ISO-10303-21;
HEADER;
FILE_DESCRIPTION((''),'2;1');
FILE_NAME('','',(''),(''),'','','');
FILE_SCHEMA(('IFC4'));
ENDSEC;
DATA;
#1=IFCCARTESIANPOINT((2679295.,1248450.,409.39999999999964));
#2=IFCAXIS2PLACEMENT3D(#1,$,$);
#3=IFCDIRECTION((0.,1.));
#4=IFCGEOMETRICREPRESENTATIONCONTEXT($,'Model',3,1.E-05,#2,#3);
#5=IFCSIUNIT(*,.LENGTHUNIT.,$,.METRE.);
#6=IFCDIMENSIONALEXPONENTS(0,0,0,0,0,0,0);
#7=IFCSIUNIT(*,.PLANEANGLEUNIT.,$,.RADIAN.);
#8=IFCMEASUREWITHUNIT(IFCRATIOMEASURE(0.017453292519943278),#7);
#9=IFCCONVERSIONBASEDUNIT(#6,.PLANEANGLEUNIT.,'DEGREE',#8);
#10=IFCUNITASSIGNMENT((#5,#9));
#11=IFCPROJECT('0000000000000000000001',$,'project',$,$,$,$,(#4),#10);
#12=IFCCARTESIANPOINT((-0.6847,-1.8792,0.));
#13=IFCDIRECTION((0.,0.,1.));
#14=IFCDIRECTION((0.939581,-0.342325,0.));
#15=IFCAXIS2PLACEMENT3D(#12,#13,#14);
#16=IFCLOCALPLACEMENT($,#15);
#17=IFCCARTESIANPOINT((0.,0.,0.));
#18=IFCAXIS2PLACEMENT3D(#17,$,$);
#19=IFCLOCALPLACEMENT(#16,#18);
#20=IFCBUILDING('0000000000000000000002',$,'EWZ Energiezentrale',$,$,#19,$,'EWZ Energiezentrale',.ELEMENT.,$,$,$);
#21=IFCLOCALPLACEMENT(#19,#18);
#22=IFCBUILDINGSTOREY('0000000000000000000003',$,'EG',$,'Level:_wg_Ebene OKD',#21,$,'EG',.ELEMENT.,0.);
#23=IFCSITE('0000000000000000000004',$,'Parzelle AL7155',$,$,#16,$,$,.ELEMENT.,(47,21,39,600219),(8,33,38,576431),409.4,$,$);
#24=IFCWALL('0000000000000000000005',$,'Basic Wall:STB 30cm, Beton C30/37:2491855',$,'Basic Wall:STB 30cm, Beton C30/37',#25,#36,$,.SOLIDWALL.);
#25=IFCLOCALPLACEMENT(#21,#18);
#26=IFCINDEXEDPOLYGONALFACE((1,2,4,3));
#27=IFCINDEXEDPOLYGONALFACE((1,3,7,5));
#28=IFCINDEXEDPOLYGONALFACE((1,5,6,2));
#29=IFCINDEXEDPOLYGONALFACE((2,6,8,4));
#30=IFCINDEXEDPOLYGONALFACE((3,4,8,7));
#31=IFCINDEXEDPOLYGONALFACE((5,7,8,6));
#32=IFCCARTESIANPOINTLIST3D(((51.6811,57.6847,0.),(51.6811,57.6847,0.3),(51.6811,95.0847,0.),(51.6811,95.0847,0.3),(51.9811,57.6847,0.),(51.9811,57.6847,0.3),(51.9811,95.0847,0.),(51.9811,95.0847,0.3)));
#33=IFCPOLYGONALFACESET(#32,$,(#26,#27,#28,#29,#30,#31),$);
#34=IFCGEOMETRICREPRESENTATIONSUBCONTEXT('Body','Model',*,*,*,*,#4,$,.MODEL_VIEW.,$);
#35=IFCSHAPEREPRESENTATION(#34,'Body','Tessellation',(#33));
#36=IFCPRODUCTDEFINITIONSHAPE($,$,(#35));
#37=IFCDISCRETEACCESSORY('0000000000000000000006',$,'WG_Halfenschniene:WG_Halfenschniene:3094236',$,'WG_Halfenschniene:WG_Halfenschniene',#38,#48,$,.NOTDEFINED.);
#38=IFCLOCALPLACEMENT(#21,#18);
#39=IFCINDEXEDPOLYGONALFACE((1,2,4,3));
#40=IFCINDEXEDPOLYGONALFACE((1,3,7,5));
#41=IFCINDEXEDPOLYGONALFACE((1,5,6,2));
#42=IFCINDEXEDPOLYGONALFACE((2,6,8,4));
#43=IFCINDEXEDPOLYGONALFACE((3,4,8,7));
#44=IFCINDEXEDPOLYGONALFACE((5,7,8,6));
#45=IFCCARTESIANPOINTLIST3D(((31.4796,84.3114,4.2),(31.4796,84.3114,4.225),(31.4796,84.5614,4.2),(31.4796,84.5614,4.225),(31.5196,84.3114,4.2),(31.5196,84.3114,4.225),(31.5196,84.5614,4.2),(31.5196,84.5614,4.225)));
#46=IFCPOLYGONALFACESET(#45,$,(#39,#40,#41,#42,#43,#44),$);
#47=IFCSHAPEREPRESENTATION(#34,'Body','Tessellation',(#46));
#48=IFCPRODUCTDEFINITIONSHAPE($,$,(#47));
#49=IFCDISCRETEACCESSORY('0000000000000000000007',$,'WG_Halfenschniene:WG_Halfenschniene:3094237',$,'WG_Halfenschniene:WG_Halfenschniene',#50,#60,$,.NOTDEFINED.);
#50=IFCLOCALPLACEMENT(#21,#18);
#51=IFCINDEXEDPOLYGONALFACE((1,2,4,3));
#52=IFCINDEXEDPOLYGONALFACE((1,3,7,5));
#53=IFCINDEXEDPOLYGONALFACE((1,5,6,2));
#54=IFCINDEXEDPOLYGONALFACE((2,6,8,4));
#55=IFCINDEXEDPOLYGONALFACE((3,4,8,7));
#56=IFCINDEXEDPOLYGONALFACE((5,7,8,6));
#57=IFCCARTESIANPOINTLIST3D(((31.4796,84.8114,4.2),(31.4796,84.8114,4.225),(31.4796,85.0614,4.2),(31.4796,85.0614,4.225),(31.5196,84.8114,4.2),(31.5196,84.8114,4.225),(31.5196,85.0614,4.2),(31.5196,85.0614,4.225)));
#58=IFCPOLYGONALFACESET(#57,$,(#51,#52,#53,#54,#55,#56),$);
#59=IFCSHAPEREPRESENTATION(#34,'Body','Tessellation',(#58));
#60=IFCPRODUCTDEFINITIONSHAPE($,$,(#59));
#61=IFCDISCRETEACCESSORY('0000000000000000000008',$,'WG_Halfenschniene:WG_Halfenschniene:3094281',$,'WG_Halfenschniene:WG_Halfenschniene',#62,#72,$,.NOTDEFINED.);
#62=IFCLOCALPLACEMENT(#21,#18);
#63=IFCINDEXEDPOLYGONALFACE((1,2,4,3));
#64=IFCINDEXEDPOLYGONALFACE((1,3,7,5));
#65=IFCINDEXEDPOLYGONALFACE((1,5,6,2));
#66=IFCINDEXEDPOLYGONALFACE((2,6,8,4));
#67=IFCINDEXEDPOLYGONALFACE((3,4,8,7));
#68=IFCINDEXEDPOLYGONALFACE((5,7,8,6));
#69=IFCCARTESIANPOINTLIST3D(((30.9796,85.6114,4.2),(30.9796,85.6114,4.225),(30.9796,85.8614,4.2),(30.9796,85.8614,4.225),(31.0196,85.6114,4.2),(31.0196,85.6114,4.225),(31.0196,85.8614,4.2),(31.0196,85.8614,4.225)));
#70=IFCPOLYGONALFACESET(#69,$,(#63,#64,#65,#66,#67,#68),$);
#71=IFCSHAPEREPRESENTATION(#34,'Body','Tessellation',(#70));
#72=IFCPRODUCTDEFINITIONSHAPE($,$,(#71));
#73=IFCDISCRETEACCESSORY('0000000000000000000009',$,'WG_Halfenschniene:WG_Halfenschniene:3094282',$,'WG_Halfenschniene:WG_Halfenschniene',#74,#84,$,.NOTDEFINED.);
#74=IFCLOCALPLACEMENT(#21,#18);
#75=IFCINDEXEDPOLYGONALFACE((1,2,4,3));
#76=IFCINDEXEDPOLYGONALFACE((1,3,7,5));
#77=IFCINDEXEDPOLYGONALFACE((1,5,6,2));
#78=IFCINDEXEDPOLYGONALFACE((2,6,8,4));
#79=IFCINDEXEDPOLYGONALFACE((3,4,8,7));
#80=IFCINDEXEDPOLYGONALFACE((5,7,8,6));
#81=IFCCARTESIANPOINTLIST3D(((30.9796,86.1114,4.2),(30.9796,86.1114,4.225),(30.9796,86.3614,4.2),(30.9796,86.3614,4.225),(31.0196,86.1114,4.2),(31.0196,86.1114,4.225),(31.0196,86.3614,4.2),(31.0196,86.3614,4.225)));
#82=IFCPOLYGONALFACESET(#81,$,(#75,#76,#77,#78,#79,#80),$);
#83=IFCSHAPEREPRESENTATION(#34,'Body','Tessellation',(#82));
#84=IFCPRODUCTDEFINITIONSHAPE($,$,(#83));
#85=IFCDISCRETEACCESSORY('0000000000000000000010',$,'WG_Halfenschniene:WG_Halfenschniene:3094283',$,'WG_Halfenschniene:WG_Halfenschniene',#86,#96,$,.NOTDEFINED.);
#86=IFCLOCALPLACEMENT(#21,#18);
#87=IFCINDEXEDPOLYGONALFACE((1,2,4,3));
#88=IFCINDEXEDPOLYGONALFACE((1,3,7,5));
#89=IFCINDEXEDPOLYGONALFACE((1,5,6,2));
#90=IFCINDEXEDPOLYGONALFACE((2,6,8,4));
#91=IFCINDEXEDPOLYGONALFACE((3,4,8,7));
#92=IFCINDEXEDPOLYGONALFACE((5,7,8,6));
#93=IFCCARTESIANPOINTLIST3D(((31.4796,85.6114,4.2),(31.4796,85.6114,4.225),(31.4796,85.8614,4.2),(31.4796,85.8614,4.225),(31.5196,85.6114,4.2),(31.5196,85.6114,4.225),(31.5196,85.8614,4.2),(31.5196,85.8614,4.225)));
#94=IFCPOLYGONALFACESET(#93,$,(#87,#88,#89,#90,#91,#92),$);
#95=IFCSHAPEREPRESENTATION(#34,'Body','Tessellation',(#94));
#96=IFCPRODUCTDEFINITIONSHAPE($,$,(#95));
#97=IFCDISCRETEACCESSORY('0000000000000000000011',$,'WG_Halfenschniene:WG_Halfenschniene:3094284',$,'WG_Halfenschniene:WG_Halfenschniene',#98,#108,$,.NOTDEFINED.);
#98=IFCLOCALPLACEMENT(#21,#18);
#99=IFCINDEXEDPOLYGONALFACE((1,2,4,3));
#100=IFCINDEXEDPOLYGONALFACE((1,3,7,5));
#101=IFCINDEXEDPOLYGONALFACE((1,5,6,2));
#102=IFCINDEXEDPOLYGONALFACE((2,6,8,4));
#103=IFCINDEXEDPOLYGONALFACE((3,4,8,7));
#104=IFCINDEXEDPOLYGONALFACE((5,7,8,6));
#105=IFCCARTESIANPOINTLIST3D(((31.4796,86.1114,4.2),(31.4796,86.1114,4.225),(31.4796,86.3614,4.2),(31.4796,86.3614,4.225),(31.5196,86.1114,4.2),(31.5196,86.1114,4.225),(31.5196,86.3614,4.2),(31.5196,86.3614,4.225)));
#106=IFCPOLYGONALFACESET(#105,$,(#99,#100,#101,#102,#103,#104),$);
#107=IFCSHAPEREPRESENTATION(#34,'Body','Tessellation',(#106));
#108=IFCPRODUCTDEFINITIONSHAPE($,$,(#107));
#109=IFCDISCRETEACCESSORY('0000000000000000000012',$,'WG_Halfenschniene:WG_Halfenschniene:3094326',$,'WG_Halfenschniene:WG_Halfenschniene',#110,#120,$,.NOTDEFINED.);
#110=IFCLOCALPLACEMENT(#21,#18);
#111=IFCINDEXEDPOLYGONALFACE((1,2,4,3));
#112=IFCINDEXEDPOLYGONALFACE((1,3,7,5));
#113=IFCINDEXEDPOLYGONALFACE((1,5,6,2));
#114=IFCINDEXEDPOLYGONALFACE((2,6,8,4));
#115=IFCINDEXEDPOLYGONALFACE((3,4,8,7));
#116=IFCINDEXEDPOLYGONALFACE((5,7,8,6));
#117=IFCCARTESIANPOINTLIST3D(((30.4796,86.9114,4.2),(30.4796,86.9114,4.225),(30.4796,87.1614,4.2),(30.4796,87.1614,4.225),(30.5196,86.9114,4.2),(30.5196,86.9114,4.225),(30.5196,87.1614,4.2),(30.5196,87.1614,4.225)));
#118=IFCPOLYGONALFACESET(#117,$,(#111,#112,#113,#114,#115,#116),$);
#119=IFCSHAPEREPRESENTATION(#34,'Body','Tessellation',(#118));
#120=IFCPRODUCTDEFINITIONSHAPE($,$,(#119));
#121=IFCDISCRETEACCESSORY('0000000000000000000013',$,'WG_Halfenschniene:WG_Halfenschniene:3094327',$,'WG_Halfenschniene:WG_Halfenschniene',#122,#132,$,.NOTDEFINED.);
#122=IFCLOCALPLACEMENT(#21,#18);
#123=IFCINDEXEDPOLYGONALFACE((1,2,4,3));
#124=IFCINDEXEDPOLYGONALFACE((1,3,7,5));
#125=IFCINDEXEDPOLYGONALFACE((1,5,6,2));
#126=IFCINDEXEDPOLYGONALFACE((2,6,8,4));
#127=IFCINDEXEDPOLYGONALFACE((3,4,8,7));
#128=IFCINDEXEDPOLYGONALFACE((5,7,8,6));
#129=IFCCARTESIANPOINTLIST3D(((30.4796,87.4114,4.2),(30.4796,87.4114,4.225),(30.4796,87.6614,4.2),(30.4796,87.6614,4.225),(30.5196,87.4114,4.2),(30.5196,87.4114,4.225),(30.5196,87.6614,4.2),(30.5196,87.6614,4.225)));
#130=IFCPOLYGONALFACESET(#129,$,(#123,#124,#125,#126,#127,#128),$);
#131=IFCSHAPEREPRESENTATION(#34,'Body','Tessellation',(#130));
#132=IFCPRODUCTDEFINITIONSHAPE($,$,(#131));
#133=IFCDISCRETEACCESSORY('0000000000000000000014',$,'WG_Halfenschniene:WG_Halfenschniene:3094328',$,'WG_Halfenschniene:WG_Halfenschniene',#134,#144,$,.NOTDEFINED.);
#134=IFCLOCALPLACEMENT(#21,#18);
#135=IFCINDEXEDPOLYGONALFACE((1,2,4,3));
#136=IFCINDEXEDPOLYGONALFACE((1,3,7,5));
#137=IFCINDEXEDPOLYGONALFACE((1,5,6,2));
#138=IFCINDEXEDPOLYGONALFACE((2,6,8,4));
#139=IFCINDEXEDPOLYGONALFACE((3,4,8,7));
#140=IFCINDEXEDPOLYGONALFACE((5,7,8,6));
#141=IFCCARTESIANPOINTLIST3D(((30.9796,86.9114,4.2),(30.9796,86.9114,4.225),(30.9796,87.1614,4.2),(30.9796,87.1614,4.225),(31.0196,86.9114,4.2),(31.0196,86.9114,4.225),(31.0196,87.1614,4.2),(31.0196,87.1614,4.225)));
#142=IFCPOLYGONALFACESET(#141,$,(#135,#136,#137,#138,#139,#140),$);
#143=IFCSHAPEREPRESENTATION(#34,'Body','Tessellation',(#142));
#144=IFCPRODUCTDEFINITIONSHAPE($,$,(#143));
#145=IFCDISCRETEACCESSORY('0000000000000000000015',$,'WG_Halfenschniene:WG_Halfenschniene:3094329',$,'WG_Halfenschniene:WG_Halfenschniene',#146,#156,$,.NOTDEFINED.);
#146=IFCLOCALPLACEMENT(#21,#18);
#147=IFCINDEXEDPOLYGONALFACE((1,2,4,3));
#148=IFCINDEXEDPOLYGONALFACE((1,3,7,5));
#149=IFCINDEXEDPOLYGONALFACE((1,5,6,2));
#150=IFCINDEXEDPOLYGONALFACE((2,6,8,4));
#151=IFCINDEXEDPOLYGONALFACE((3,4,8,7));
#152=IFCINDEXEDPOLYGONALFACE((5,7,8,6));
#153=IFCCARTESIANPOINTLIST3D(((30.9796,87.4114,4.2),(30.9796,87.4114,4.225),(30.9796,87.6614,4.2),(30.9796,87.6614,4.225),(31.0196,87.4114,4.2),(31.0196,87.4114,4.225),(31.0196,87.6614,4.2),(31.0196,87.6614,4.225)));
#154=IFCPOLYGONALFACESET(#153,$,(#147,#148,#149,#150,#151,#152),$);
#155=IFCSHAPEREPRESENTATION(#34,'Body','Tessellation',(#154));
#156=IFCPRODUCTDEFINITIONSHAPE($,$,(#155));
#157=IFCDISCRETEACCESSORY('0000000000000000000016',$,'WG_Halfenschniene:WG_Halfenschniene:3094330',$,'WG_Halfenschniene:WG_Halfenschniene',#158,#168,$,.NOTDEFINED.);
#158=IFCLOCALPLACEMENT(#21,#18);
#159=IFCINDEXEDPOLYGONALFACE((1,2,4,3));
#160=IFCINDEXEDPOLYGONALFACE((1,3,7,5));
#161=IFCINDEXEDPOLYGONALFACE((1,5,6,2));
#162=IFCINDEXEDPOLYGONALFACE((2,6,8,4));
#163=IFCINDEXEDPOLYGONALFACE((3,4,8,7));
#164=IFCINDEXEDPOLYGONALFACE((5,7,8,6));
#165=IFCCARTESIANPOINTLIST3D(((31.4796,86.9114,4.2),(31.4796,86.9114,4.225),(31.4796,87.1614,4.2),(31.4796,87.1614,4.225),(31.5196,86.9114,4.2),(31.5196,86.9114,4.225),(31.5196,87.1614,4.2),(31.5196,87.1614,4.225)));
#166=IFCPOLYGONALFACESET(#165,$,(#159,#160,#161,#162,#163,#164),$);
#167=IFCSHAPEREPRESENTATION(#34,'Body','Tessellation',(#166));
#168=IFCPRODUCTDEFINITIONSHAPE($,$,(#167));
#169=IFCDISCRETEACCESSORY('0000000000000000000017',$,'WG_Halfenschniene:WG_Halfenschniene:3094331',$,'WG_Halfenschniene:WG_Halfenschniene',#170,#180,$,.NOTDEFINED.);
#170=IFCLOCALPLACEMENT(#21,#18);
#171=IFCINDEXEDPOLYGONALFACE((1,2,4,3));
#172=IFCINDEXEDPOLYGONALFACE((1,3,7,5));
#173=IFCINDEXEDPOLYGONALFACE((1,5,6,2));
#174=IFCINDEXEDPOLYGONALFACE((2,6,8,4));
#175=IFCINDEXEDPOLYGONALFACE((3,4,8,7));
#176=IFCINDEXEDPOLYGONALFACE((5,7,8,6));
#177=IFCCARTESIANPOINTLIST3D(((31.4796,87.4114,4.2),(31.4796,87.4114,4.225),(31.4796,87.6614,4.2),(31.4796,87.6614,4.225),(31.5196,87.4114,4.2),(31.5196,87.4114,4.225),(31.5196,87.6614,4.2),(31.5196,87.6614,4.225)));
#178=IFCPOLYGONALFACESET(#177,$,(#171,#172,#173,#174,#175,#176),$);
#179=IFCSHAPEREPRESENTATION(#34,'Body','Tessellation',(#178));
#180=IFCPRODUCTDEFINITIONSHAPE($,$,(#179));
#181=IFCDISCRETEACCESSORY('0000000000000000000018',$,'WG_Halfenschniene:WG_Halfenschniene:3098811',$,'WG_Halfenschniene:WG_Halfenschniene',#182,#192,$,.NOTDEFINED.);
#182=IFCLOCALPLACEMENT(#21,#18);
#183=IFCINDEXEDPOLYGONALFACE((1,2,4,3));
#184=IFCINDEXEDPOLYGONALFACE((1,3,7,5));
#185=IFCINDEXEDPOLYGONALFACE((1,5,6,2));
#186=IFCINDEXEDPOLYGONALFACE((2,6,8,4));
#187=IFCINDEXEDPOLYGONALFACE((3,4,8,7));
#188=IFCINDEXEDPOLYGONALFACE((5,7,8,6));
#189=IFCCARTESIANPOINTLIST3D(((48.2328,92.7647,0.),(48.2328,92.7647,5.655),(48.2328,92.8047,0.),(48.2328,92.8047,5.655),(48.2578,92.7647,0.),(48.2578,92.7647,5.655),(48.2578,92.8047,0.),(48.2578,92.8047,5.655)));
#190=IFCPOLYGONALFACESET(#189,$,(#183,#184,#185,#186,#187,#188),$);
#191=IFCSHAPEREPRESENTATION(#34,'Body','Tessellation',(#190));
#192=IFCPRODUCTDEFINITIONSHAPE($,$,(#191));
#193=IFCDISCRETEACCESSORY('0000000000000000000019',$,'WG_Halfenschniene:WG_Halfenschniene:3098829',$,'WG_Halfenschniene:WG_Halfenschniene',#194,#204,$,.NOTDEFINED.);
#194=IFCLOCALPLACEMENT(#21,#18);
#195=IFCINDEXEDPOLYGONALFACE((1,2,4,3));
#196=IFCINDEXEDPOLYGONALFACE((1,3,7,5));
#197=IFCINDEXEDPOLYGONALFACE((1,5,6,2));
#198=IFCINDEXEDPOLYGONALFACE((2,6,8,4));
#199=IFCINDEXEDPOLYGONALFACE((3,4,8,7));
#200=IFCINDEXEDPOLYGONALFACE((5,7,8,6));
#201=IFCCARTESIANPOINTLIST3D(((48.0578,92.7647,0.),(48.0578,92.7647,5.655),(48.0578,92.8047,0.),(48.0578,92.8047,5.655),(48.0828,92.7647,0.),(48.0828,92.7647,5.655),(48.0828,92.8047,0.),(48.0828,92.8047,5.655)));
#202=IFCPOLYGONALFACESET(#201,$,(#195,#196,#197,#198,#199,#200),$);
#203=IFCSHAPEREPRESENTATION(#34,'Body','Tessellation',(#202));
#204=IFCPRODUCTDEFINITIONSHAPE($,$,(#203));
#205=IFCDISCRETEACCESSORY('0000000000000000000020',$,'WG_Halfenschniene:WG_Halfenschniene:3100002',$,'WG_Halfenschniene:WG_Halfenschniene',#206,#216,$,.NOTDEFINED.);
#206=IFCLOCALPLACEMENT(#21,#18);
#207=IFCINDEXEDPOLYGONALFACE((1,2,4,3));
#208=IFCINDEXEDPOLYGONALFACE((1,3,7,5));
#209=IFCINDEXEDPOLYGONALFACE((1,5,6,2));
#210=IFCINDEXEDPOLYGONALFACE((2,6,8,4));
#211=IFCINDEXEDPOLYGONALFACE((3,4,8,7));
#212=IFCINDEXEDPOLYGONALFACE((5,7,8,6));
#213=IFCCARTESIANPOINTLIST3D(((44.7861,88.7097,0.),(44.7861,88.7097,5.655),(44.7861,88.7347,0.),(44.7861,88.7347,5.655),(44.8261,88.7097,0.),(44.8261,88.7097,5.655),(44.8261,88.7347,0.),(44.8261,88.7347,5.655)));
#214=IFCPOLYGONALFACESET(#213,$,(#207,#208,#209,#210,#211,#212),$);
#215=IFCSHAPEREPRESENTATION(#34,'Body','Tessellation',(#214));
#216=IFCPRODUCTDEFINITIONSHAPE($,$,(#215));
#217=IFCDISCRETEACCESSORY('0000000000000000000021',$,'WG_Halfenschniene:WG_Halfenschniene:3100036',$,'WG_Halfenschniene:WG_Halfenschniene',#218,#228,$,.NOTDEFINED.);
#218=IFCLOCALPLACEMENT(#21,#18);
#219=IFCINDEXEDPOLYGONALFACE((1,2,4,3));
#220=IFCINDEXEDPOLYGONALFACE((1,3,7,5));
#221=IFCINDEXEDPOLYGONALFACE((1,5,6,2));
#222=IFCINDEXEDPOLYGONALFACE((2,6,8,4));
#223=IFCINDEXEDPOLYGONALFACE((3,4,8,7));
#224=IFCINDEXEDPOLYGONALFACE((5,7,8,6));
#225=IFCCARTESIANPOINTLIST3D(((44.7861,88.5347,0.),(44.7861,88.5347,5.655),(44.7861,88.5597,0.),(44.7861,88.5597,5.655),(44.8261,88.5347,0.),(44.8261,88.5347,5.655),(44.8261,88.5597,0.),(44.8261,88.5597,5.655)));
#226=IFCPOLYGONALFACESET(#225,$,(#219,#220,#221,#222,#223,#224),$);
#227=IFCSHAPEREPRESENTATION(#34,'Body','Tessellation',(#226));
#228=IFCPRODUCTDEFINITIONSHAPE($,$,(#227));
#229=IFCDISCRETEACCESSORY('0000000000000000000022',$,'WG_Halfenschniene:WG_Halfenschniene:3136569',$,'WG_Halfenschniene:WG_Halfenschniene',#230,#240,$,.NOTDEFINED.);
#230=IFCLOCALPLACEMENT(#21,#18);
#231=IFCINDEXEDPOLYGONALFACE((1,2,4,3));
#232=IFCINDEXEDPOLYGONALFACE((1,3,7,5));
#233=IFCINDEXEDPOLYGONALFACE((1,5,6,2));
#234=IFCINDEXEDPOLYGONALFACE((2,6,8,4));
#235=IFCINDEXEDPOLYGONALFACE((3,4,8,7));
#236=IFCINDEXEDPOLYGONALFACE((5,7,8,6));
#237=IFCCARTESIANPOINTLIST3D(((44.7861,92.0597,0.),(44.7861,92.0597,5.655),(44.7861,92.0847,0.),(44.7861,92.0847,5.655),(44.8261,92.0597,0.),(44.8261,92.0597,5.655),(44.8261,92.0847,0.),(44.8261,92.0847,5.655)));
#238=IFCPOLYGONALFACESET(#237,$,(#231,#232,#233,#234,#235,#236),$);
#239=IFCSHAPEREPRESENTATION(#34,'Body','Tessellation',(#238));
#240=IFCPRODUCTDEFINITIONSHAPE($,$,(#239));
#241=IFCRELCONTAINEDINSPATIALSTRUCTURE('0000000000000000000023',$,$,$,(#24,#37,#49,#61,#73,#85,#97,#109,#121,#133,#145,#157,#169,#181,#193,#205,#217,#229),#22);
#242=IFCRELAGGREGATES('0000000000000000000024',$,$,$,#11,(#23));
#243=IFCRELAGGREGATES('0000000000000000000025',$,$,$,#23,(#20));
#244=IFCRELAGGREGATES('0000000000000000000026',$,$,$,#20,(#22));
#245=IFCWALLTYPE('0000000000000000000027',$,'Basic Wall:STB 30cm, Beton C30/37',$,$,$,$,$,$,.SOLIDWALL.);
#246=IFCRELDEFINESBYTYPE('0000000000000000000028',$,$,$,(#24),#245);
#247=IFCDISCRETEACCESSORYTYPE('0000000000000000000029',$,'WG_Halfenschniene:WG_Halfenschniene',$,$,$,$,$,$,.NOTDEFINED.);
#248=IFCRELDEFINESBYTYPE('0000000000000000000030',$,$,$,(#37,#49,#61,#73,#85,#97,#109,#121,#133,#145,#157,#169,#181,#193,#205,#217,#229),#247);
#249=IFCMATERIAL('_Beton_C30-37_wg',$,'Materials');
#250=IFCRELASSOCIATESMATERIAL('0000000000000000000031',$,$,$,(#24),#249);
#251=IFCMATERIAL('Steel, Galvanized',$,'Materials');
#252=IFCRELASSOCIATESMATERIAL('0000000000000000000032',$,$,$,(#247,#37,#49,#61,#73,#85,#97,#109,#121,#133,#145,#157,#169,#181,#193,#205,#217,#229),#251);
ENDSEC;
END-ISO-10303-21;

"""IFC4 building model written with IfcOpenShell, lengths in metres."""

from ifc_helpers import new_model, entity, si_unit, converted_unit, direction, frame, origin, place, context, subcontext, project, spatial, indexed_curve, outline, extrude, source, transform, mapped, material, type_object, element, save


model = new_model("IFC4")

# Units and contexts
model_context = context("Model", 3, precision=1e-05, world=frame((2679295.0, 1248450.0, 409.39999999999964)), true_north=direction((0.0, 1.0)))
body_context = subcontext(model_context, "Body", "Model", "MODEL_VIEW")
ifc_project = project(units=[si_unit("LENGTHUNIT", "METRE"), converted_unit("PLANEANGLEUNIT", "DEGREE", entity("IfcRatioMeasure", 0.017453292519943278), si_unit("PLANEANGLEUNIT", "RADIAN"), dimensions=[0, 0, 0, 0, 0, 0, 0])], contexts=[model_context])

# Site, building, storey
site_placement = place(None, frame((-0.6847, -1.8792, 0.0), z_axis=(0.0, 0.0, 1.0), x_axis=(0.939581, -0.342325, 0.0)))
site = spatial("IfcSite", under=ifc_project, at=site_placement, Name="Parzelle AL7155", CompositionType="ELEMENT", RefLatitude=(47, 21, 39, 600219), RefLongitude=(8, 33, 38, 576431), RefElevation=409.4)
building_placement = place(site_placement, origin())
building = spatial("IfcBuilding", under=site, at=building_placement, Name="EWZ Energiezentrale", LongName="EWZ Energiezentrale", CompositionType="ELEMENT")
storey_placement = place(building_placement, origin())
storey = spatial("IfcBuildingStorey", under=building, at=storey_placement, Name="EG", ObjectType="Level:_wg_Ebene OKD", LongName="EG", CompositionType="ELEMENT", Elevation=0.0)

# Wall
ifc_material_1 = material(Name="_Beton_C30-37_wg", Category="Materials")
wall_type = type_object("IfcWallType", Name="Basic Wall:STB 30cm, Beton C30/37", PredefinedType="SOLIDWALL")
wall_placement = place(storey_placement, frame((51.8311, 95.0847, 0.0), z_axis=(0.0, 0.0, 1.0), x_axis=(0.0, -1.0, 0.0)))
element("IfcWall", 1, at=wall_placement, inside=storey, type_object=wall_type, material=ifc_material_1, Name="Basic Wall:STB 30cm, Beton C30/37:2491855", ObjectType="Basic Wall:STB 30cm, Beton C30/37", PredefinedType="SOLIDWALL", context=body_context, shape_type="SweptSolid", body=[
    extrude(outline(indexed_curve([(37.4, 0.15), (0.0, 0.15), (0.0, -0.15), (37.4, -0.15), (37.4, 0.15)], self_intersect=False)), origin(), (0.0, 0.0, 1.0), 0.3),
])

# Discrete accessories
ifc_material_2 = material(Name="Steel, Galvanized", Category="Materials")
discrete_accessory_type = type_object("IfcDiscreteAccessoryType", Name="WG_Halfenschniene:WG_Halfenschniene", PredefinedType="NOTDEFINED", material=ifc_material_2)
shared_shape_1 = source(origin(), body_context, "Body", "SweptSolid", [
    extrude(outline(indexed_curve([(-0.125, -0.02), (0.125, -0.02), (0.125, 0.02), (-0.125, 0.02), (-0.125, -0.02)], self_intersect=False)), frame((0.125, 0.0, -0.0125)), (0.0, 0.0, 1.0), 0.025),
])
for number, where, z_axis, x_axis, name in (
    (2, (31.4996, 84.3114, 4.2125), (0.0, 0.0, -1.0), (0.0, 1.0, 0.0), "WG_Halfenschniene:WG_Halfenschniene:3094236"),
    (3, (31.4996, 84.8114, 4.2125), (0.0, 0.0, -1.0), (0.0, 1.0, 0.0), "WG_Halfenschniene:WG_Halfenschniene:3094237"),
    (4, (30.9996, 85.6114, 4.2125), (0.0, 0.0, -1.0), (0.0, 1.0, 0.0), "WG_Halfenschniene:WG_Halfenschniene:3094281"),
    (5, (30.9996, 86.1114, 4.2125), (0.0, 0.0, -1.0), (0.0, 1.0, 0.0), "WG_Halfenschniene:WG_Halfenschniene:3094282"),
    (6, (31.4996, 85.6114, 4.2125), (0.0, 0.0, -1.0), (0.0, 1.0, 0.0), "WG_Halfenschniene:WG_Halfenschniene:3094283"),
    (7, (31.4996, 86.1114, 4.2125), (0.0, 0.0, -1.0), (0.0, 1.0, 0.0), "WG_Halfenschniene:WG_Halfenschniene:3094284"),
    (8, (30.4996, 86.9114, 4.2125), (0.0, 0.0, -1.0), (0.0, 1.0, 0.0), "WG_Halfenschniene:WG_Halfenschniene:3094326"),
    (9, (30.4996, 87.4114, 4.2125), (0.0, 0.0, -1.0), (0.0, 1.0, 0.0), "WG_Halfenschniene:WG_Halfenschniene:3094327"),
    (10, (30.9996, 86.9114, 4.2125), (0.0, 0.0, -1.0), (0.0, 1.0, 0.0), "WG_Halfenschniene:WG_Halfenschniene:3094328"),
    (11, (30.9996, 87.4114, 4.2125), (0.0, 0.0, -1.0), (0.0, 1.0, 0.0), "WG_Halfenschniene:WG_Halfenschniene:3094329"),
    (12, (31.4996, 86.9114, 4.2125), (0.0, 0.0, -1.0), (0.0, 1.0, 0.0), "WG_Halfenschniene:WG_Halfenschniene:3094330"),
    (13, (31.4996, 87.4114, 4.2125), (0.0, 0.0, -1.0), (0.0, 1.0, 0.0), "WG_Halfenschniene:WG_Halfenschniene:3094331"),
):
    element("IfcDiscreteAccessory", number, at=place(storey_placement, frame(where, z_axis=z_axis, x_axis=x_axis)), inside=storey, type_object=discrete_accessory_type, material=ifc_material_2, Name=name, ObjectType="WG_Halfenschniene:WG_Halfenschniene", PredefinedType="NOTDEFINED", context=body_context, shape_type="MappedRepresentation", body=[
        mapped(shared_shape_1, transform((0.0, 0.0, 0.0), scale=1.0)),
    ])
shared_shape_2 = source(origin(), body_context, "Body", "SweptSolid", [
    extrude(outline(indexed_curve([(-2.8275, -0.02), (2.8275, -0.02), (2.8275, 0.02), (-2.8275, 0.02), (-2.8275, -0.02)], self_intersect=False)), frame((2.8275, 0.0, -0.0125)), (0.0, 0.0, 1.0), 0.025),
])
for number, where, z_axis, x_axis, name in (
    (14, (48.2453, 92.7847, 5.655), (1.0, 0.0, 0.0), (0.0, 0.0, -1.0), "WG_Halfenschniene:WG_Halfenschniene:3098811"),
    (15, (48.0703, 92.7847, 5.655), (1.0, 0.0, 0.0), (0.0, 0.0, -1.0), "WG_Halfenschniene:WG_Halfenschniene:3098829"),
    (16, (44.8061, 88.7222, 5.655), (0.0, 1.0, 0.0), (0.0, 0.0, -1.0), "WG_Halfenschniene:WG_Halfenschniene:3100002"),
    (17, (44.8061, 88.5472, 5.655), (0.0, 1.0, 0.0), (0.0, 0.0, -1.0), "WG_Halfenschniene:WG_Halfenschniene:3100036"),
    (18, (44.8061, 92.0722, 5.655), (0.0, 1.0, 0.0), (0.0, 0.0, -1.0), "WG_Halfenschniene:WG_Halfenschniene:3136569"),
):
    element("IfcDiscreteAccessory", number, at=place(storey_placement, frame(where, z_axis=z_axis, x_axis=x_axis)), inside=storey, type_object=discrete_accessory_type, material=ifc_material_2, Name=name, ObjectType="WG_Halfenschniene:WG_Halfenschniene", PredefinedType="NOTDEFINED", context=body_context, shape_type="MappedRepresentation", body=[
        mapped(shared_shape_2, transform((0.0, 0.0, 0.0), scale=1.0)),
    ])

save(model, "model.ifc")
